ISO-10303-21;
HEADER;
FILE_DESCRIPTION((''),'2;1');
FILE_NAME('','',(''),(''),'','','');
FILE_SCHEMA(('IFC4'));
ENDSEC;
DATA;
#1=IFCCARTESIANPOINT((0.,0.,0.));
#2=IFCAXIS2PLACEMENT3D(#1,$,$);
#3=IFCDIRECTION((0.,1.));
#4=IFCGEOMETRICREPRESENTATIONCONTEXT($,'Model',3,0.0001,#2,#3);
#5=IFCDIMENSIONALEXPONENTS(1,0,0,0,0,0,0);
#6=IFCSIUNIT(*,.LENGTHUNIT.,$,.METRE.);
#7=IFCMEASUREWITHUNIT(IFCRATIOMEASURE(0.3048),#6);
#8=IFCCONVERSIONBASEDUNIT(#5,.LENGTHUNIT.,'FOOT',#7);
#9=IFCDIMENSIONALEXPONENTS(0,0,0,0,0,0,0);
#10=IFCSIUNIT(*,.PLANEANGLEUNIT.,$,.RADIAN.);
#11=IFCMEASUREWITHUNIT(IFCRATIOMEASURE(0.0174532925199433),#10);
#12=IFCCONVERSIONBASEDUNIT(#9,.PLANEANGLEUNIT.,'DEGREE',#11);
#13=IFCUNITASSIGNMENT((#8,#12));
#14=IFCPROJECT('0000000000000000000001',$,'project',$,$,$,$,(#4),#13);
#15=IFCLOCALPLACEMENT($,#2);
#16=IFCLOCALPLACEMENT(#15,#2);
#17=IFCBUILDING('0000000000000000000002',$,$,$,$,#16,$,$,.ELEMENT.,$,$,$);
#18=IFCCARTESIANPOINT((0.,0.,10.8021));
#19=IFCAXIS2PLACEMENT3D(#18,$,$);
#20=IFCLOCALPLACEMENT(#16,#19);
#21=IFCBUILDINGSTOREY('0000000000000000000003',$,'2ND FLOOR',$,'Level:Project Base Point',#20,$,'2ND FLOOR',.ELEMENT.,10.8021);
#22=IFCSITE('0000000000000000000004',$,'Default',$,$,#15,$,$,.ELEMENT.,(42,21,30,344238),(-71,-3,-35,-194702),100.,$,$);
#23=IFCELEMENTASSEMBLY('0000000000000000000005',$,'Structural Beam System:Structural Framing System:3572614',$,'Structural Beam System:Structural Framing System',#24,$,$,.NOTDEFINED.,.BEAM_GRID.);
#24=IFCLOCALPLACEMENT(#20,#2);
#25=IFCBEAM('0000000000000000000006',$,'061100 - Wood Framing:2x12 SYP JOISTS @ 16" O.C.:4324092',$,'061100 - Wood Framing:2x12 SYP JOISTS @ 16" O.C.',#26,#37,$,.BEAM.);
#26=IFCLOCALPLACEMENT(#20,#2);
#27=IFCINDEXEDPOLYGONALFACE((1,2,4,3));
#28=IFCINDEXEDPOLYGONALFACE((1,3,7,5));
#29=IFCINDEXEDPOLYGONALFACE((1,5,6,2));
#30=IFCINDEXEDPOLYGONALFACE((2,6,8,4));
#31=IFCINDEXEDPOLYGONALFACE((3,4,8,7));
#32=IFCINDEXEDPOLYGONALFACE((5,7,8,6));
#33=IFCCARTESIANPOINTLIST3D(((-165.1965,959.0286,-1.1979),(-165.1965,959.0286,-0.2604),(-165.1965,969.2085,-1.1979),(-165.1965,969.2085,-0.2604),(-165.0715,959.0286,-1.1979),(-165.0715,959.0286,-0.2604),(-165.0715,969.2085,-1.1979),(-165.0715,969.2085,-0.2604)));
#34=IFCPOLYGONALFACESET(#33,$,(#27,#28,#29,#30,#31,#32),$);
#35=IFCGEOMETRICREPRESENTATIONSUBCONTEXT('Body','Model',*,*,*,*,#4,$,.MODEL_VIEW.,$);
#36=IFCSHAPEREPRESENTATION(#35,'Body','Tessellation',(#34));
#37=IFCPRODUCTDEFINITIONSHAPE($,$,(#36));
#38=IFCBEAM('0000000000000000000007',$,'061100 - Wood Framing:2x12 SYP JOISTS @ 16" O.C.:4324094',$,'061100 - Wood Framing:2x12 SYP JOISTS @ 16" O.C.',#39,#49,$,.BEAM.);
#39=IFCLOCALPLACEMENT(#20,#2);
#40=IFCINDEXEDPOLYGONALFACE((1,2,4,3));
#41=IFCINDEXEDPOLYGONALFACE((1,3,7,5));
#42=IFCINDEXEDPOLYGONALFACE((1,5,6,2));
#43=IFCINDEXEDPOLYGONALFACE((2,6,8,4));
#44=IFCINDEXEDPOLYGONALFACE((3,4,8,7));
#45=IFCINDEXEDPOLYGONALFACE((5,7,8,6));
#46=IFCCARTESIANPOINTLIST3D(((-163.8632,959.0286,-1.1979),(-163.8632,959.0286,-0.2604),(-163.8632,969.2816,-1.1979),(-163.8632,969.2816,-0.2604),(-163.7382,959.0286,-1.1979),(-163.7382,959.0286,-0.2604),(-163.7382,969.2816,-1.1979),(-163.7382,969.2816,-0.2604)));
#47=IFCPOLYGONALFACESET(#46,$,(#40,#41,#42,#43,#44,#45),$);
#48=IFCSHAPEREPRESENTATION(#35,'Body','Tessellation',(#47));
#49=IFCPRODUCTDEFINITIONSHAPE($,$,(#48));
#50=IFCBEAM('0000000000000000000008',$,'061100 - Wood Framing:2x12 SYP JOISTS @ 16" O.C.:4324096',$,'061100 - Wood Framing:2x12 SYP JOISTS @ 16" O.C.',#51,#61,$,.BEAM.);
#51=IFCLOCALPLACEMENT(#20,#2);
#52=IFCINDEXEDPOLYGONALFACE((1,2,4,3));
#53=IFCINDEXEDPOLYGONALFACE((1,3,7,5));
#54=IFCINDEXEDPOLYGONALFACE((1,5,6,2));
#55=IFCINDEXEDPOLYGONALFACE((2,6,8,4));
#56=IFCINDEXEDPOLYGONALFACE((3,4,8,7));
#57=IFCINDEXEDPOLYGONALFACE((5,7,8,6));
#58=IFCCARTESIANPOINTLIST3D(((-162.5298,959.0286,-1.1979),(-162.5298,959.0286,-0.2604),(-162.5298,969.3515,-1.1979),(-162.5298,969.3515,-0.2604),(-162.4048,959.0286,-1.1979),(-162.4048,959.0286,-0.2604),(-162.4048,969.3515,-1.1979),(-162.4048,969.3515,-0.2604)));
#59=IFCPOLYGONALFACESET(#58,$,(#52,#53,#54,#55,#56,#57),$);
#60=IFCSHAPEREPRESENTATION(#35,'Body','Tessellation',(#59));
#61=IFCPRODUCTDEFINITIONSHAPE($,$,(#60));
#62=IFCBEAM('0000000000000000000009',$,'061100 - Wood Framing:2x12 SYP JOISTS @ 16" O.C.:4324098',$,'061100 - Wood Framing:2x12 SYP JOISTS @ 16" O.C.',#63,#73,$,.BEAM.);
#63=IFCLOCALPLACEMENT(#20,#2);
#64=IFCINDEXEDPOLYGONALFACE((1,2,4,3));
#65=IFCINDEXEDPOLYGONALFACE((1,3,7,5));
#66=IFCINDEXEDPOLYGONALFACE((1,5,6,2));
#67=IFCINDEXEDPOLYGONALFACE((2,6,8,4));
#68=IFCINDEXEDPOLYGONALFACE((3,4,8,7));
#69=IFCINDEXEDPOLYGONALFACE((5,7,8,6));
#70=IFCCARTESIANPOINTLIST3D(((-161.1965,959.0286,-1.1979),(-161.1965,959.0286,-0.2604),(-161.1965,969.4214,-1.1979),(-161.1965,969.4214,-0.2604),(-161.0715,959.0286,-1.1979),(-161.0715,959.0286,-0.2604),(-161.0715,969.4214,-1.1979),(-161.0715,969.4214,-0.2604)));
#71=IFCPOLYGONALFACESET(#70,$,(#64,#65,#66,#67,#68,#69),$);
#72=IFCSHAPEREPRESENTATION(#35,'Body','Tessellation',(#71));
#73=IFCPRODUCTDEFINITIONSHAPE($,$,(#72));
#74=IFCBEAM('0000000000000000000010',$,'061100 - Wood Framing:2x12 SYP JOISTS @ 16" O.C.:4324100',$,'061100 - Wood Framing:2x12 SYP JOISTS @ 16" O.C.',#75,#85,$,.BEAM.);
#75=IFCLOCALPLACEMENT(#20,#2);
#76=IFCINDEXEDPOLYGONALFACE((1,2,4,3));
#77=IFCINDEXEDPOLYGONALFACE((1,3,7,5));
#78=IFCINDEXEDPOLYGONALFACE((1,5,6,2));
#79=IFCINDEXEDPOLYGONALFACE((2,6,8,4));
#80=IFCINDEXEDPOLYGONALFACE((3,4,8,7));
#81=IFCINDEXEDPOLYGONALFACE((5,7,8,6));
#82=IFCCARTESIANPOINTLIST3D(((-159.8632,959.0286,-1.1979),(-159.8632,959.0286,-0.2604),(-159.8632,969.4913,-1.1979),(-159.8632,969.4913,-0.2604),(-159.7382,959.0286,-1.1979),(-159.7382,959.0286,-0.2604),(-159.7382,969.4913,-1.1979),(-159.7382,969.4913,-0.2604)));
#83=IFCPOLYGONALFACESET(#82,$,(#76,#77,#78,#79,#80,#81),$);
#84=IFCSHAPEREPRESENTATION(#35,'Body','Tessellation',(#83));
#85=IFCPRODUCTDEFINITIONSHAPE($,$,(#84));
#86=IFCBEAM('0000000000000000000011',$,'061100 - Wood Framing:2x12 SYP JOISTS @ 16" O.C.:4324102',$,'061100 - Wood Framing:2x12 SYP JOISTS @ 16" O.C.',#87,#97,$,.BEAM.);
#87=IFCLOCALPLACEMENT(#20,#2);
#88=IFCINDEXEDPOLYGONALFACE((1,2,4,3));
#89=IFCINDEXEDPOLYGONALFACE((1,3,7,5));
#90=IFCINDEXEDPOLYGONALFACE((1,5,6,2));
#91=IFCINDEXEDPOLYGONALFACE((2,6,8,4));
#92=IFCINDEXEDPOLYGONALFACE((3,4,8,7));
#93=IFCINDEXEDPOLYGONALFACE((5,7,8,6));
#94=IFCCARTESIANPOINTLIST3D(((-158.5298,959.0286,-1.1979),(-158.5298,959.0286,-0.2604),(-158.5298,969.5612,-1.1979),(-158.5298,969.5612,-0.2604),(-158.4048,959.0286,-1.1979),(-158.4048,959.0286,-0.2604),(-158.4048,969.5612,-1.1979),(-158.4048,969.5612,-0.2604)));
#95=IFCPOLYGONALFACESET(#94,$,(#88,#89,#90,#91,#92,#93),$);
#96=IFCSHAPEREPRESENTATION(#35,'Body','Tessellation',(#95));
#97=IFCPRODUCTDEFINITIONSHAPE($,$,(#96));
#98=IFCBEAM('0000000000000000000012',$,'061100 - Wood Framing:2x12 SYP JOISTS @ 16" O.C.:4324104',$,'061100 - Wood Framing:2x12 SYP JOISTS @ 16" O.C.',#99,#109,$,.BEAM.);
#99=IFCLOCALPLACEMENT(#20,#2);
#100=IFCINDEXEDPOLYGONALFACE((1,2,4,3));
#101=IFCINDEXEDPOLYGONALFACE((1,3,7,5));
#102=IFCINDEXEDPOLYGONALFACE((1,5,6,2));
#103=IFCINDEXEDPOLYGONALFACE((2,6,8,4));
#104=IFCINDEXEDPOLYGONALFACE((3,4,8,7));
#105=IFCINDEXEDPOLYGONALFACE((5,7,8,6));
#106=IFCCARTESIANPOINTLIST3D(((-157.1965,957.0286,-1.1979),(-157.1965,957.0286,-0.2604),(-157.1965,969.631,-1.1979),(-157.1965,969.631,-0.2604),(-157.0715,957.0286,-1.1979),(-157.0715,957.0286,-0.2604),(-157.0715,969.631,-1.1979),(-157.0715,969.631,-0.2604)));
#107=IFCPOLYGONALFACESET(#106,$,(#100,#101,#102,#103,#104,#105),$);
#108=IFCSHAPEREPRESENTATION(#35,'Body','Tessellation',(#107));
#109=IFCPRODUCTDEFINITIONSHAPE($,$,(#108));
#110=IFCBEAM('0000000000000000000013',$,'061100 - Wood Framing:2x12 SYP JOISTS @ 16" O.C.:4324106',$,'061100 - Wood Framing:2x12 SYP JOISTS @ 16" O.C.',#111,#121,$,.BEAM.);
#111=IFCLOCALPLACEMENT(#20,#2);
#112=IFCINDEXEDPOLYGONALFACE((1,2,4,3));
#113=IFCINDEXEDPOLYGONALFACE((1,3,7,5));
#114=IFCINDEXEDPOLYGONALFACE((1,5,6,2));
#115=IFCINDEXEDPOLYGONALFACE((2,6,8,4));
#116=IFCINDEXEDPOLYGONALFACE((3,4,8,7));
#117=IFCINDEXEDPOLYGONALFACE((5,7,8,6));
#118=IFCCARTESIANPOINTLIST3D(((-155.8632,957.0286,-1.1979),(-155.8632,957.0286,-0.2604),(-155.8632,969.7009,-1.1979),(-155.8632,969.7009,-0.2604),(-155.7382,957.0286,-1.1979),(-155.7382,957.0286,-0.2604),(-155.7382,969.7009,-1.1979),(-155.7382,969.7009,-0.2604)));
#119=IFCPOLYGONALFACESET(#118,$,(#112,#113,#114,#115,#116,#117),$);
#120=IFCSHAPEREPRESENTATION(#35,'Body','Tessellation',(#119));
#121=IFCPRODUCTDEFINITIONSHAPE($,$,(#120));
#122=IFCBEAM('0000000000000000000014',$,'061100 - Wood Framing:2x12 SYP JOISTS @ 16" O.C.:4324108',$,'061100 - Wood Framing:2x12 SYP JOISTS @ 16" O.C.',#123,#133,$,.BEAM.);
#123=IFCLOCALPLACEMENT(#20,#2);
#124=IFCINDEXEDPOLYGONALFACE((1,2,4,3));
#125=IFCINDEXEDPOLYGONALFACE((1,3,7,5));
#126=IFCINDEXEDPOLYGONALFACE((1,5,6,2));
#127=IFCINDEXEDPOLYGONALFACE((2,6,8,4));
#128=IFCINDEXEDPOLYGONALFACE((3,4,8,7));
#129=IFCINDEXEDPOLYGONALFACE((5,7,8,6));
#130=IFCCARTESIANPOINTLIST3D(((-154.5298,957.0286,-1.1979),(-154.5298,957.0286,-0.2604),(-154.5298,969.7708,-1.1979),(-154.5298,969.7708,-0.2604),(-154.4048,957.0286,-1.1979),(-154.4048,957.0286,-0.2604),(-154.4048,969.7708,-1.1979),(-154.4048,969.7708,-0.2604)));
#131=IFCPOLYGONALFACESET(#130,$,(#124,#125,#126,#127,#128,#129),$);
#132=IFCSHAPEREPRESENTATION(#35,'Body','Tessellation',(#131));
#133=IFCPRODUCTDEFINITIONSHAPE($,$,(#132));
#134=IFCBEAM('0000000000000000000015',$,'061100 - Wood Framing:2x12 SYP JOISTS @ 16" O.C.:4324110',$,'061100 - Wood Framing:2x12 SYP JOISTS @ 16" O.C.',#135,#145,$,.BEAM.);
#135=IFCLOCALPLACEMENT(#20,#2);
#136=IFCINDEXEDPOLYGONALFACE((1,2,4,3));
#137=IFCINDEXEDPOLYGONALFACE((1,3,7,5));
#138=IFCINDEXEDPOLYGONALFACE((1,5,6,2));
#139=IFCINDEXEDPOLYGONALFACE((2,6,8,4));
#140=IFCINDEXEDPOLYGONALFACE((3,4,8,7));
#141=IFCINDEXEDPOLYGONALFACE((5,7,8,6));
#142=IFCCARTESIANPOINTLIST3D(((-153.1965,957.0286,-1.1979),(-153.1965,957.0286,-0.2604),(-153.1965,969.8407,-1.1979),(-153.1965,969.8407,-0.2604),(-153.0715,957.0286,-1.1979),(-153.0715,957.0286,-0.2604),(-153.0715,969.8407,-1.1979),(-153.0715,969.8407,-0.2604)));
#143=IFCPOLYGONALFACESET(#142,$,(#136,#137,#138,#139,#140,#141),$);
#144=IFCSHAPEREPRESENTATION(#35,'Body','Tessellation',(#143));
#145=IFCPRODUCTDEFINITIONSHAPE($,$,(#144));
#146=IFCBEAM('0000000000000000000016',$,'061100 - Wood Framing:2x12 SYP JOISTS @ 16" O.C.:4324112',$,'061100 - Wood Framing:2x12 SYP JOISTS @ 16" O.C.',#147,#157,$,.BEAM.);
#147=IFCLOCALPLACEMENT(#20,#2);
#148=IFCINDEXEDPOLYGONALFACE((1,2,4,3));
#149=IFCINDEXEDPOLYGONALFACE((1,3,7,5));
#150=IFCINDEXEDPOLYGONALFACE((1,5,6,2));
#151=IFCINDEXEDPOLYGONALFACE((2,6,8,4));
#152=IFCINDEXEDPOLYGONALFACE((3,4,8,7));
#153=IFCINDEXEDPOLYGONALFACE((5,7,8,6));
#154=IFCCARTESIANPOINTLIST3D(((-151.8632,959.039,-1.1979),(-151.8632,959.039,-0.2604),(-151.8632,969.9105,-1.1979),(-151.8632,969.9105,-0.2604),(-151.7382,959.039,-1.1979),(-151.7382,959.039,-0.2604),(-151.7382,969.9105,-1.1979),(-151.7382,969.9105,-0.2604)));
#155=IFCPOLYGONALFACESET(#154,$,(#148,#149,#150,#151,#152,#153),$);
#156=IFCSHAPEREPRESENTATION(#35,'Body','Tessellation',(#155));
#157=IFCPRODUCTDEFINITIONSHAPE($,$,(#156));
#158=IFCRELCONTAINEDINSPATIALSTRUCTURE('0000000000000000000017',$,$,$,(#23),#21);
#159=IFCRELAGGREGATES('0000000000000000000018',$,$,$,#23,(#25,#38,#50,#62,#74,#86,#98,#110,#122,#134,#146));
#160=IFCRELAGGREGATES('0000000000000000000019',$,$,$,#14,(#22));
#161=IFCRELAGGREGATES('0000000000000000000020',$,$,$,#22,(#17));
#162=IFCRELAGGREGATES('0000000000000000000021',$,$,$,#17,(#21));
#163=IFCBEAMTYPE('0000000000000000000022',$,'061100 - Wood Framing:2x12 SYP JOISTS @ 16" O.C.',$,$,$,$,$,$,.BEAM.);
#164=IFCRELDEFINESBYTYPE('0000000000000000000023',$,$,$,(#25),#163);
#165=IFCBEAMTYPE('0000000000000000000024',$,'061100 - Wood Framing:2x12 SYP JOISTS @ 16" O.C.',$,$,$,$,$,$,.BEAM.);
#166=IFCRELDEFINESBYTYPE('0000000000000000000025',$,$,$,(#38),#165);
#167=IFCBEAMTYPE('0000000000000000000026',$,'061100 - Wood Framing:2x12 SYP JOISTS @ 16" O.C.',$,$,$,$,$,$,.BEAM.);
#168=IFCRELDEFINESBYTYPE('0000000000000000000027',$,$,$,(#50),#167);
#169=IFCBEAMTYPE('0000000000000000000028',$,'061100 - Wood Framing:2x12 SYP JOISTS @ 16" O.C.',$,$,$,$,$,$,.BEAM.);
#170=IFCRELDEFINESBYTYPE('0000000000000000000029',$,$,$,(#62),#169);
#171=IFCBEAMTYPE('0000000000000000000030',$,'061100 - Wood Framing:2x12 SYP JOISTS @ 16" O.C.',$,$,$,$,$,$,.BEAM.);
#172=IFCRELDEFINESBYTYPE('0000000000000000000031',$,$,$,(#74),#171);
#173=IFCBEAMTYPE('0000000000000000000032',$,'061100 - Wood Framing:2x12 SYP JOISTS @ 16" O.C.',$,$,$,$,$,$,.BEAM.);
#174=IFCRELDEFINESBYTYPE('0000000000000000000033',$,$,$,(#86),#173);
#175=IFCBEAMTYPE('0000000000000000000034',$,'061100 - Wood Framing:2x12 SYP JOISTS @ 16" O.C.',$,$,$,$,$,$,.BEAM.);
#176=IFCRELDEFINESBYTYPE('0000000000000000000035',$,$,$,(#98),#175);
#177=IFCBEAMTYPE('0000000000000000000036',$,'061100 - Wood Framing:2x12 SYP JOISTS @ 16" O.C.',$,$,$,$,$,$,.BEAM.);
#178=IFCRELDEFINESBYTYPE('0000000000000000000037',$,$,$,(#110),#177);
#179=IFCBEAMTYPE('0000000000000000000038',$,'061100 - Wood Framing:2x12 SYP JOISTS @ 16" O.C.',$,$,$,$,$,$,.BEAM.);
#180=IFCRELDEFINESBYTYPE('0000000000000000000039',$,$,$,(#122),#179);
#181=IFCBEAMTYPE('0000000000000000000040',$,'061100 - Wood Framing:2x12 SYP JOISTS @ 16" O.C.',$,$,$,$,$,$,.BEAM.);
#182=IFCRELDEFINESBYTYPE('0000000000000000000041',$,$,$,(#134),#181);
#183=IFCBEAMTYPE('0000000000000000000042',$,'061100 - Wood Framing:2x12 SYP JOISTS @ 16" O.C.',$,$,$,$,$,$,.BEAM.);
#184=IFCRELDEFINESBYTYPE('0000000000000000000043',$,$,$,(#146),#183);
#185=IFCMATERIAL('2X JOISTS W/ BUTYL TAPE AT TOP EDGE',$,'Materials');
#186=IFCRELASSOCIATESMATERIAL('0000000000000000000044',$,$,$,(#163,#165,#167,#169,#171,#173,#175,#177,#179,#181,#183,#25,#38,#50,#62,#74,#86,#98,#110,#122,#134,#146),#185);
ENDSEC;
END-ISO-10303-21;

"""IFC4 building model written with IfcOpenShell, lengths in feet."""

from ifc_helpers import new_model, entity, si_unit, converted_unit, direction, frame, origin, origin_2d_with_axis, place, context, subcontext, project, spatial, rectangle, extrude, source, transform, mapped, material, material_profile, profile_set, profile_usage, type_object, type_shapes, element, aggregate, save


model = new_model("IFC4")

# Units and contexts
model_context = context("Model", 3, precision=0.0001, world=origin(), true_north=direction((0.0, 1.0)))
body_context = subcontext(model_context, "Body", "Model", "MODEL_VIEW")
ifc_project = project(units=[converted_unit("LENGTHUNIT", "FOOT", entity("IfcRatioMeasure", 0.3048), si_unit("LENGTHUNIT", "METRE"), dimensions=[1, 0, 0, 0, 0, 0, 0]), converted_unit("PLANEANGLEUNIT", "DEGREE", entity("IfcRatioMeasure", 0.0174532925199433), si_unit("PLANEANGLEUNIT", "RADIAN"), dimensions=[0, 0, 0, 0, 0, 0, 0])], contexts=[model_context])

# Site, building, storey
site_placement = place(None, origin())
site = spatial("IfcSite", under=ifc_project, at=site_placement, Name="Default", CompositionType="ELEMENT", RefLatitude=(42, 21, 30, 344238), RefLongitude=(-71, -3, -35, -194702), RefElevation=100.0)
building_placement = place(site_placement, origin())
building = spatial("IfcBuilding", under=site, at=building_placement, CompositionType="ELEMENT")
storey_placement = place(building_placement, frame((0.0, 0.0, 10.8021)))
storey = spatial("IfcBuildingStorey", under=building, at=storey_placement, Name="2ND FLOOR", ObjectType="Level:Project Base Point", LongName="2ND FLOOR", CompositionType="ELEMENT", Elevation=10.8021)

# Element assembly, beams
assembly_placement = place(storey_placement, origin())
assembly = element("IfcElementAssembly", 1, at=assembly_placement, inside=storey, Name="Structural Beam System:Structural Framing System:3572614", ObjectType="Structural Beam System:Structural Framing System", AssemblyPlace="NOTDEFINED", PredefinedType="BEAM_GRID")
ifc_material_1 = material(Name="2X JOISTS W/ BUTYL TAPE AT TOP EDGE", Category="Materials")
ifc_material_profile = material_profile(ifc_material_1, rectangle(XDim=0.9375, YDim=0.125, at=origin_2d_with_axis()), Name="2x12 SYP JOISTS @ 16\" O.C.")
ifc_profile_set = profile_set([ifc_material_profile], Name="2x12 SYP JOISTS @ 16\" O.C.")
ifc_profile_usage_1 = profile_usage(ifc_profile_set, cardinal=8)
beam_type_1 = type_object("IfcBeamType", Name="061100 - Wood Framing:2x12 SYP JOISTS @ 16\" O.C.", PredefinedType="BEAM", material=ifc_profile_set)
shared_shape_1 = source(origin(), body_context, "Body", "SweptSolid", [
    extrude(rectangle(XDim=0.9375, YDim=0.125, at=origin_2d_with_axis()), frame((-5.1229, 0.0, 0.0), z_axis=(1.0, 0.0, 0.0), x_axis=(0.0, 0.0, -1.0)), (0.0, 0.0, 1.0), 10.1799),
])
type_shapes(beam_type_1, [shared_shape_1])
beam_1_placement = place(assembly_placement, frame((-165.134, 964.1515, -0.7292), z_axis=(0.0, 0.0, 1.0), x_axis=(0.0, 1.0, 0.0)))
beam_1 = element("IfcBeam", 2, at=beam_1_placement, type_object=beam_type_1, material=ifc_profile_usage_1, Name="061100 - Wood Framing:2x12 SYP JOISTS @ 16\" O.C.:4324092", ObjectType="061100 - Wood Framing:2x12 SYP JOISTS @ 16\" O.C.", PredefinedType="BEAM", context=body_context, shape_type="MappedRepresentation", body=[
    mapped(shared_shape_1, transform((0.0, 0.0, 0.0), scale=1.0)),
])
ifc_profile_usage_2 = profile_usage(ifc_profile_set, cardinal=8)
beam_type_2 = type_object("IfcBeamType", Name="061100 - Wood Framing:2x12 SYP JOISTS @ 16\" O.C.", PredefinedType="BEAM", material=ifc_profile_set)
shared_shape_2 = source(origin(), body_context, "Body", "SweptSolid", [
    extrude(rectangle(XDim=0.9375, YDim=0.125, at=origin_2d_with_axis()), frame((-5.1265, 0.0, 0.0), z_axis=(1.0, 0.0, 0.0), x_axis=(0.0, 0.0, -1.0)), (0.0, 0.0, 1.0), 10.253),
])
type_shapes(beam_type_2, [shared_shape_2])
beam_2_placement = place(assembly_placement, frame((-163.8007, 964.1551, -0.7292), z_axis=(0.0, 0.0, 1.0), x_axis=(0.0, 1.0, 0.0)))
beam_2 = element("IfcBeam", 3, at=beam_2_placement, type_object=beam_type_2, material=ifc_profile_usage_2, Name="061100 - Wood Framing:2x12 SYP JOISTS @ 16\" O.C.:4324094", ObjectType="061100 - Wood Framing:2x12 SYP JOISTS @ 16\" O.C.", PredefinedType="BEAM", context=body_context, shape_type="MappedRepresentation", body=[
    mapped(shared_shape_2, transform((0.0, 0.0, 0.0), scale=1.0)),
])
ifc_profile_usage_3 = profile_usage(ifc_profile_set, cardinal=8)
beam_type_3 = type_object("IfcBeamType", Name="061100 - Wood Framing:2x12 SYP JOISTS @ 16\" O.C.", PredefinedType="BEAM", material=ifc_profile_set)
shared_shape_3 = source(origin(), body_context, "Body", "SweptSolid", [
    extrude(rectangle(XDim=0.9375, YDim=0.125, at=origin_2d_with_axis()), frame((-5.1615, 0.0, 0.0), z_axis=(1.0, 0.0, 0.0), x_axis=(0.0, 0.0, -1.0)), (0.0, 0.0, 1.0), 10.3229),
])
type_shapes(beam_type_3, [shared_shape_3])
beam_3_placement = place(assembly_placement, frame((-162.4673, 964.1901, -0.7292), z_axis=(0.0, 0.0, 1.0), x_axis=(0.0, 1.0, 0.0)))
beam_3 = element("IfcBeam", 4, at=beam_3_placement, type_object=beam_type_3, material=ifc_profile_usage_3, Name="061100 - Wood Framing:2x12 SYP JOISTS @ 16\" O.C.:4324096", ObjectType="061100 - Wood Framing:2x12 SYP JOISTS @ 16\" O.C.", PredefinedType="BEAM", context=body_context, shape_type="MappedRepresentation", body=[
    mapped(shared_shape_3, transform((0.0, 0.0, 0.0), scale=1.0)),
])
ifc_profile_usage_4 = profile_usage(ifc_profile_set, cardinal=8)
beam_type_4 = type_object("IfcBeamType", Name="061100 - Wood Framing:2x12 SYP JOISTS @ 16\" O.C.", PredefinedType="BEAM", material=ifc_profile_set)
shared_shape_4 = source(origin(), body_context, "Body", "SweptSolid", [
    extrude(rectangle(XDim=0.9375, YDim=0.125, at=origin_2d_with_axis()), frame((-5.1964, 0.0, 0.0), z_axis=(1.0, 0.0, 0.0), x_axis=(0.0, 0.0, -1.0)), (0.0, 0.0, 1.0), 10.3928),
])
type_shapes(beam_type_4, [shared_shape_4])
beam_4_placement = place(assembly_placement, frame((-161.134, 964.225, -0.7292), z_axis=(0.0, 0.0, 1.0), x_axis=(0.0, 1.0, 0.0)))
beam_4 = element("IfcBeam", 5, at=beam_4_placement, type_object=beam_type_4, material=ifc_profile_usage_4, Name="061100 - Wood Framing:2x12 SYP JOISTS @ 16\" O.C.:4324098", ObjectType="061100 - Wood Framing:2x12 SYP JOISTS @ 16\" O.C.", PredefinedType="BEAM", context=body_context, shape_type="MappedRepresentation", body=[
    mapped(shared_shape_4, transform((0.0, 0.0, 0.0), scale=1.0)),
])
ifc_profile_usage_5 = profile_usage(ifc_profile_set, cardinal=8)
beam_type_5 = type_object("IfcBeamType", Name="061100 - Wood Framing:2x12 SYP JOISTS @ 16\" O.C.", PredefinedType="BEAM", material=ifc_profile_set)
shared_shape_5 = source(origin(), body_context, "Body", "SweptSolid", [
    extrude(rectangle(XDim=0.9375, YDim=0.125, at=origin_2d_with_axis()), frame((-5.2313, 0.0, 0.0), z_axis=(1.0, 0.0, 0.0), x_axis=(0.0, 0.0, -1.0)), (0.0, 0.0, 1.0), 10.4627),
])
type_shapes(beam_type_5, [shared_shape_5])
beam_5_placement = place(assembly_placement, frame((-159.8007, 964.2599, -0.7292), z_axis=(0.0, 0.0, 1.0), x_axis=(0.0, 1.0, 0.0)))
beam_5 = element("IfcBeam", 6, at=beam_5_placement, type_object=beam_type_5, material=ifc_profile_usage_5, Name="061100 - Wood Framing:2x12 SYP JOISTS @ 16\" O.C.:4324100", ObjectType="061100 - Wood Framing:2x12 SYP JOISTS @ 16\" O.C.", PredefinedType="BEAM", context=body_context, shape_type="MappedRepresentation", body=[
    mapped(shared_shape_5, transform((0.0, 0.0, 0.0), scale=1.0)),
])
ifc_profile_usage_6 = profile_usage(ifc_profile_set, cardinal=8)
beam_type_6 = type_object("IfcBeamType", Name="061100 - Wood Framing:2x12 SYP JOISTS @ 16\" O.C.", PredefinedType="BEAM", material=ifc_profile_set)
shared_shape_6 = source(origin(), body_context, "Body", "SweptSolid", [
    extrude(rectangle(XDim=0.9375, YDim=0.125, at=origin_2d_with_axis()), frame((-5.2663, 0.0, 0.0), z_axis=(1.0, 0.0, 0.0), x_axis=(0.0, 0.0, -1.0)), (0.0, 0.0, 1.0), 10.5325),
])
type_shapes(beam_type_6, [shared_shape_6])
beam_6_placement = place(assembly_placement, frame((-158.4673, 964.2949, -0.7292), z_axis=(0.0, 0.0, 1.0), x_axis=(0.0, 1.0, 0.0)))
beam_6 = element("IfcBeam", 7, at=beam_6_placement, type_object=beam_type_6, material=ifc_profile_usage_6, Name="061100 - Wood Framing:2x12 SYP JOISTS @ 16\" O.C.:4324102", ObjectType="061100 - Wood Framing:2x12 SYP JOISTS @ 16\" O.C.", PredefinedType="BEAM", context=body_context, shape_type="MappedRepresentation", body=[
    mapped(shared_shape_6, transform((0.0, 0.0, 0.0), scale=1.0)),
])
ifc_profile_usage_7 = profile_usage(ifc_profile_set, cardinal=8)
beam_type_7 = type_object("IfcBeamType", Name="061100 - Wood Framing:2x12 SYP JOISTS @ 16\" O.C.", PredefinedType="BEAM", material=ifc_profile_set)
shared_shape_7 = source(origin(), body_context, "Body", "SweptSolid", [
    extrude(rectangle(XDim=0.9375, YDim=0.125, at=origin_2d_with_axis()), frame((-6.3012, 0.0, 0.0), z_axis=(1.0, 0.0, 0.0), x_axis=(0.0, 0.0, -1.0)), (0.0, 0.0, 1.0), 12.6024),
])
type_shapes(beam_type_7, [shared_shape_7])
beam_7_placement = place(assembly_placement, frame((-157.134, 963.3298, -0.7292), z_axis=(0.0, 0.0, 1.0), x_axis=(0.0, 1.0, 0.0)))
beam_7 = element("IfcBeam", 8, at=beam_7_placement, type_object=beam_type_7, material=ifc_profile_usage_7, Name="061100 - Wood Framing:2x12 SYP JOISTS @ 16\" O.C.:4324104", ObjectType="061100 - Wood Framing:2x12 SYP JOISTS @ 16\" O.C.", PredefinedType="BEAM", context=body_context, shape_type="MappedRepresentation", body=[
    mapped(shared_shape_7, transform((0.0, 0.0, 0.0), scale=1.0)),
])
ifc_profile_usage_8 = profile_usage(ifc_profile_set, cardinal=8)
beam_type_8 = type_object("IfcBeamType", Name="061100 - Wood Framing:2x12 SYP JOISTS @ 16\" O.C.", PredefinedType="BEAM", material=ifc_profile_set)
shared_shape_8 = source(origin(), body_context, "Body", "SweptSolid", [
    extrude(rectangle(XDim=0.9375, YDim=0.125, at=origin_2d_with_axis()), frame((-6.3362, 0.0, 0.0), z_axis=(1.0, 0.0, 0.0), x_axis=(0.0, 0.0, -1.0)), (0.0, 0.0, 1.0), 12.6723),
])
type_shapes(beam_type_8, [shared_shape_8])
beam_8_placement = place(assembly_placement, frame((-155.8007, 963.3648, -0.7292), z_axis=(0.0, 0.0, 1.0), x_axis=(0.0, 1.0, 0.0)))
beam_8 = element("IfcBeam", 9, at=beam_8_placement, type_object=beam_type_8, material=ifc_profile_usage_8, Name="061100 - Wood Framing:2x12 SYP JOISTS @ 16\" O.C.:4324106", ObjectType="061100 - Wood Framing:2x12 SYP JOISTS @ 16\" O.C.", PredefinedType="BEAM", context=body_context, shape_type="MappedRepresentation", body=[
    mapped(shared_shape_8, transform((0.0, 0.0, 0.0), scale=1.0)),
])
ifc_profile_usage_9 = profile_usage(ifc_profile_set, cardinal=8)
beam_type_9 = type_object("IfcBeamType", Name="061100 - Wood Framing:2x12 SYP JOISTS @ 16\" O.C.", PredefinedType="BEAM", material=ifc_profile_set)
shared_shape_9 = source(origin(), body_context, "Body", "SweptSolid", [
    extrude(rectangle(XDim=0.9375, YDim=0.125, at=origin_2d_with_axis()), frame((-6.3711, 0.0, 0.0), z_axis=(1.0, 0.0, 0.0), x_axis=(0.0, 0.0, -1.0)), (0.0, 0.0, 1.0), 12.7422),
])
type_shapes(beam_type_9, [shared_shape_9])
beam_9_placement = place(assembly_placement, frame((-154.4673, 963.3997, -0.7292), z_axis=(0.0, 0.0, 1.0), x_axis=(0.0, 1.0, 0.0)))
beam_9 = element("IfcBeam", 10, at=beam_9_placement, type_object=beam_type_9, material=ifc_profile_usage_9, Name="061100 - Wood Framing:2x12 SYP JOISTS @ 16\" O.C.:4324108", ObjectType="061100 - Wood Framing:2x12 SYP JOISTS @ 16\" O.C.", PredefinedType="BEAM", context=body_context, shape_type="MappedRepresentation", body=[
    mapped(shared_shape_9, transform((0.0, 0.0, 0.0), scale=1.0)),
])
ifc_profile_usage_10 = profile_usage(ifc_profile_set, cardinal=8)
beam_type_10 = type_object("IfcBeamType", Name="061100 - Wood Framing:2x12 SYP JOISTS @ 16\" O.C.", PredefinedType="BEAM", material=ifc_profile_set)
shared_shape_10 = source(origin(), body_context, "Body", "SweptSolid", [
    extrude(rectangle(XDim=0.9375, YDim=0.125, at=origin_2d_with_axis()), frame((-6.406, 0.0, 0.0), z_axis=(1.0, 0.0, 0.0), x_axis=(0.0, 0.0, -1.0)), (0.0, 0.0, 1.0), 12.8121),
])
type_shapes(beam_type_10, [shared_shape_10])
beam_10_placement = place(assembly_placement, frame((-153.134, 963.4346, -0.7292), z_axis=(0.0, 0.0, 1.0), x_axis=(0.0, 1.0, 0.0)))
beam_10 = element("IfcBeam", 11, at=beam_10_placement, type_object=beam_type_10, material=ifc_profile_usage_10, Name="061100 - Wood Framing:2x12 SYP JOISTS @ 16\" O.C.:4324110", ObjectType="061100 - Wood Framing:2x12 SYP JOISTS @ 16\" O.C.", PredefinedType="BEAM", context=body_context, shape_type="MappedRepresentation", body=[
    mapped(shared_shape_10, transform((0.0, 0.0, 0.0), scale=1.0)),
])
ifc_profile_usage_11 = profile_usage(ifc_profile_set, cardinal=8)
beam_type_11 = type_object("IfcBeamType", Name="061100 - Wood Framing:2x12 SYP JOISTS @ 16\" O.C.", PredefinedType="BEAM", material=ifc_profile_set)
shared_shape_11 = source(origin(), body_context, "Body", "SweptSolid", [
    extrude(rectangle(XDim=0.9375, YDim=0.125, at=origin_2d_with_axis()), frame((-5.4358, 0.0, 0.0), z_axis=(1.0, 0.0, 0.0), x_axis=(0.0, 0.0, -1.0)), (0.0, 0.0, 1.0), 10.8715),
])
type_shapes(beam_type_11, [shared_shape_11])
beam_11_placement = place(assembly_placement, frame((-151.8007, 964.4748, -0.7292), z_axis=(0.0, 0.0, 1.0), x_axis=(0.0, 1.0, 0.0)))
beam_11 = element("IfcBeam", 12, at=beam_11_placement, type_object=beam_type_11, material=ifc_profile_usage_11, Name="061100 - Wood Framing:2x12 SYP JOISTS @ 16\" O.C.:4324112", ObjectType="061100 - Wood Framing:2x12 SYP JOISTS @ 16\" O.C.", PredefinedType="BEAM", context=body_context, shape_type="MappedRepresentation", body=[
    mapped(shared_shape_11, transform((0.0, 0.0, 0.0), scale=1.0)),
])
aggregate(assembly, [beam_1, beam_2, beam_3, beam_4, beam_5, beam_6, beam_7, beam_8, beam_9, beam_10, beam_11])

save(model, "model.ifc")
